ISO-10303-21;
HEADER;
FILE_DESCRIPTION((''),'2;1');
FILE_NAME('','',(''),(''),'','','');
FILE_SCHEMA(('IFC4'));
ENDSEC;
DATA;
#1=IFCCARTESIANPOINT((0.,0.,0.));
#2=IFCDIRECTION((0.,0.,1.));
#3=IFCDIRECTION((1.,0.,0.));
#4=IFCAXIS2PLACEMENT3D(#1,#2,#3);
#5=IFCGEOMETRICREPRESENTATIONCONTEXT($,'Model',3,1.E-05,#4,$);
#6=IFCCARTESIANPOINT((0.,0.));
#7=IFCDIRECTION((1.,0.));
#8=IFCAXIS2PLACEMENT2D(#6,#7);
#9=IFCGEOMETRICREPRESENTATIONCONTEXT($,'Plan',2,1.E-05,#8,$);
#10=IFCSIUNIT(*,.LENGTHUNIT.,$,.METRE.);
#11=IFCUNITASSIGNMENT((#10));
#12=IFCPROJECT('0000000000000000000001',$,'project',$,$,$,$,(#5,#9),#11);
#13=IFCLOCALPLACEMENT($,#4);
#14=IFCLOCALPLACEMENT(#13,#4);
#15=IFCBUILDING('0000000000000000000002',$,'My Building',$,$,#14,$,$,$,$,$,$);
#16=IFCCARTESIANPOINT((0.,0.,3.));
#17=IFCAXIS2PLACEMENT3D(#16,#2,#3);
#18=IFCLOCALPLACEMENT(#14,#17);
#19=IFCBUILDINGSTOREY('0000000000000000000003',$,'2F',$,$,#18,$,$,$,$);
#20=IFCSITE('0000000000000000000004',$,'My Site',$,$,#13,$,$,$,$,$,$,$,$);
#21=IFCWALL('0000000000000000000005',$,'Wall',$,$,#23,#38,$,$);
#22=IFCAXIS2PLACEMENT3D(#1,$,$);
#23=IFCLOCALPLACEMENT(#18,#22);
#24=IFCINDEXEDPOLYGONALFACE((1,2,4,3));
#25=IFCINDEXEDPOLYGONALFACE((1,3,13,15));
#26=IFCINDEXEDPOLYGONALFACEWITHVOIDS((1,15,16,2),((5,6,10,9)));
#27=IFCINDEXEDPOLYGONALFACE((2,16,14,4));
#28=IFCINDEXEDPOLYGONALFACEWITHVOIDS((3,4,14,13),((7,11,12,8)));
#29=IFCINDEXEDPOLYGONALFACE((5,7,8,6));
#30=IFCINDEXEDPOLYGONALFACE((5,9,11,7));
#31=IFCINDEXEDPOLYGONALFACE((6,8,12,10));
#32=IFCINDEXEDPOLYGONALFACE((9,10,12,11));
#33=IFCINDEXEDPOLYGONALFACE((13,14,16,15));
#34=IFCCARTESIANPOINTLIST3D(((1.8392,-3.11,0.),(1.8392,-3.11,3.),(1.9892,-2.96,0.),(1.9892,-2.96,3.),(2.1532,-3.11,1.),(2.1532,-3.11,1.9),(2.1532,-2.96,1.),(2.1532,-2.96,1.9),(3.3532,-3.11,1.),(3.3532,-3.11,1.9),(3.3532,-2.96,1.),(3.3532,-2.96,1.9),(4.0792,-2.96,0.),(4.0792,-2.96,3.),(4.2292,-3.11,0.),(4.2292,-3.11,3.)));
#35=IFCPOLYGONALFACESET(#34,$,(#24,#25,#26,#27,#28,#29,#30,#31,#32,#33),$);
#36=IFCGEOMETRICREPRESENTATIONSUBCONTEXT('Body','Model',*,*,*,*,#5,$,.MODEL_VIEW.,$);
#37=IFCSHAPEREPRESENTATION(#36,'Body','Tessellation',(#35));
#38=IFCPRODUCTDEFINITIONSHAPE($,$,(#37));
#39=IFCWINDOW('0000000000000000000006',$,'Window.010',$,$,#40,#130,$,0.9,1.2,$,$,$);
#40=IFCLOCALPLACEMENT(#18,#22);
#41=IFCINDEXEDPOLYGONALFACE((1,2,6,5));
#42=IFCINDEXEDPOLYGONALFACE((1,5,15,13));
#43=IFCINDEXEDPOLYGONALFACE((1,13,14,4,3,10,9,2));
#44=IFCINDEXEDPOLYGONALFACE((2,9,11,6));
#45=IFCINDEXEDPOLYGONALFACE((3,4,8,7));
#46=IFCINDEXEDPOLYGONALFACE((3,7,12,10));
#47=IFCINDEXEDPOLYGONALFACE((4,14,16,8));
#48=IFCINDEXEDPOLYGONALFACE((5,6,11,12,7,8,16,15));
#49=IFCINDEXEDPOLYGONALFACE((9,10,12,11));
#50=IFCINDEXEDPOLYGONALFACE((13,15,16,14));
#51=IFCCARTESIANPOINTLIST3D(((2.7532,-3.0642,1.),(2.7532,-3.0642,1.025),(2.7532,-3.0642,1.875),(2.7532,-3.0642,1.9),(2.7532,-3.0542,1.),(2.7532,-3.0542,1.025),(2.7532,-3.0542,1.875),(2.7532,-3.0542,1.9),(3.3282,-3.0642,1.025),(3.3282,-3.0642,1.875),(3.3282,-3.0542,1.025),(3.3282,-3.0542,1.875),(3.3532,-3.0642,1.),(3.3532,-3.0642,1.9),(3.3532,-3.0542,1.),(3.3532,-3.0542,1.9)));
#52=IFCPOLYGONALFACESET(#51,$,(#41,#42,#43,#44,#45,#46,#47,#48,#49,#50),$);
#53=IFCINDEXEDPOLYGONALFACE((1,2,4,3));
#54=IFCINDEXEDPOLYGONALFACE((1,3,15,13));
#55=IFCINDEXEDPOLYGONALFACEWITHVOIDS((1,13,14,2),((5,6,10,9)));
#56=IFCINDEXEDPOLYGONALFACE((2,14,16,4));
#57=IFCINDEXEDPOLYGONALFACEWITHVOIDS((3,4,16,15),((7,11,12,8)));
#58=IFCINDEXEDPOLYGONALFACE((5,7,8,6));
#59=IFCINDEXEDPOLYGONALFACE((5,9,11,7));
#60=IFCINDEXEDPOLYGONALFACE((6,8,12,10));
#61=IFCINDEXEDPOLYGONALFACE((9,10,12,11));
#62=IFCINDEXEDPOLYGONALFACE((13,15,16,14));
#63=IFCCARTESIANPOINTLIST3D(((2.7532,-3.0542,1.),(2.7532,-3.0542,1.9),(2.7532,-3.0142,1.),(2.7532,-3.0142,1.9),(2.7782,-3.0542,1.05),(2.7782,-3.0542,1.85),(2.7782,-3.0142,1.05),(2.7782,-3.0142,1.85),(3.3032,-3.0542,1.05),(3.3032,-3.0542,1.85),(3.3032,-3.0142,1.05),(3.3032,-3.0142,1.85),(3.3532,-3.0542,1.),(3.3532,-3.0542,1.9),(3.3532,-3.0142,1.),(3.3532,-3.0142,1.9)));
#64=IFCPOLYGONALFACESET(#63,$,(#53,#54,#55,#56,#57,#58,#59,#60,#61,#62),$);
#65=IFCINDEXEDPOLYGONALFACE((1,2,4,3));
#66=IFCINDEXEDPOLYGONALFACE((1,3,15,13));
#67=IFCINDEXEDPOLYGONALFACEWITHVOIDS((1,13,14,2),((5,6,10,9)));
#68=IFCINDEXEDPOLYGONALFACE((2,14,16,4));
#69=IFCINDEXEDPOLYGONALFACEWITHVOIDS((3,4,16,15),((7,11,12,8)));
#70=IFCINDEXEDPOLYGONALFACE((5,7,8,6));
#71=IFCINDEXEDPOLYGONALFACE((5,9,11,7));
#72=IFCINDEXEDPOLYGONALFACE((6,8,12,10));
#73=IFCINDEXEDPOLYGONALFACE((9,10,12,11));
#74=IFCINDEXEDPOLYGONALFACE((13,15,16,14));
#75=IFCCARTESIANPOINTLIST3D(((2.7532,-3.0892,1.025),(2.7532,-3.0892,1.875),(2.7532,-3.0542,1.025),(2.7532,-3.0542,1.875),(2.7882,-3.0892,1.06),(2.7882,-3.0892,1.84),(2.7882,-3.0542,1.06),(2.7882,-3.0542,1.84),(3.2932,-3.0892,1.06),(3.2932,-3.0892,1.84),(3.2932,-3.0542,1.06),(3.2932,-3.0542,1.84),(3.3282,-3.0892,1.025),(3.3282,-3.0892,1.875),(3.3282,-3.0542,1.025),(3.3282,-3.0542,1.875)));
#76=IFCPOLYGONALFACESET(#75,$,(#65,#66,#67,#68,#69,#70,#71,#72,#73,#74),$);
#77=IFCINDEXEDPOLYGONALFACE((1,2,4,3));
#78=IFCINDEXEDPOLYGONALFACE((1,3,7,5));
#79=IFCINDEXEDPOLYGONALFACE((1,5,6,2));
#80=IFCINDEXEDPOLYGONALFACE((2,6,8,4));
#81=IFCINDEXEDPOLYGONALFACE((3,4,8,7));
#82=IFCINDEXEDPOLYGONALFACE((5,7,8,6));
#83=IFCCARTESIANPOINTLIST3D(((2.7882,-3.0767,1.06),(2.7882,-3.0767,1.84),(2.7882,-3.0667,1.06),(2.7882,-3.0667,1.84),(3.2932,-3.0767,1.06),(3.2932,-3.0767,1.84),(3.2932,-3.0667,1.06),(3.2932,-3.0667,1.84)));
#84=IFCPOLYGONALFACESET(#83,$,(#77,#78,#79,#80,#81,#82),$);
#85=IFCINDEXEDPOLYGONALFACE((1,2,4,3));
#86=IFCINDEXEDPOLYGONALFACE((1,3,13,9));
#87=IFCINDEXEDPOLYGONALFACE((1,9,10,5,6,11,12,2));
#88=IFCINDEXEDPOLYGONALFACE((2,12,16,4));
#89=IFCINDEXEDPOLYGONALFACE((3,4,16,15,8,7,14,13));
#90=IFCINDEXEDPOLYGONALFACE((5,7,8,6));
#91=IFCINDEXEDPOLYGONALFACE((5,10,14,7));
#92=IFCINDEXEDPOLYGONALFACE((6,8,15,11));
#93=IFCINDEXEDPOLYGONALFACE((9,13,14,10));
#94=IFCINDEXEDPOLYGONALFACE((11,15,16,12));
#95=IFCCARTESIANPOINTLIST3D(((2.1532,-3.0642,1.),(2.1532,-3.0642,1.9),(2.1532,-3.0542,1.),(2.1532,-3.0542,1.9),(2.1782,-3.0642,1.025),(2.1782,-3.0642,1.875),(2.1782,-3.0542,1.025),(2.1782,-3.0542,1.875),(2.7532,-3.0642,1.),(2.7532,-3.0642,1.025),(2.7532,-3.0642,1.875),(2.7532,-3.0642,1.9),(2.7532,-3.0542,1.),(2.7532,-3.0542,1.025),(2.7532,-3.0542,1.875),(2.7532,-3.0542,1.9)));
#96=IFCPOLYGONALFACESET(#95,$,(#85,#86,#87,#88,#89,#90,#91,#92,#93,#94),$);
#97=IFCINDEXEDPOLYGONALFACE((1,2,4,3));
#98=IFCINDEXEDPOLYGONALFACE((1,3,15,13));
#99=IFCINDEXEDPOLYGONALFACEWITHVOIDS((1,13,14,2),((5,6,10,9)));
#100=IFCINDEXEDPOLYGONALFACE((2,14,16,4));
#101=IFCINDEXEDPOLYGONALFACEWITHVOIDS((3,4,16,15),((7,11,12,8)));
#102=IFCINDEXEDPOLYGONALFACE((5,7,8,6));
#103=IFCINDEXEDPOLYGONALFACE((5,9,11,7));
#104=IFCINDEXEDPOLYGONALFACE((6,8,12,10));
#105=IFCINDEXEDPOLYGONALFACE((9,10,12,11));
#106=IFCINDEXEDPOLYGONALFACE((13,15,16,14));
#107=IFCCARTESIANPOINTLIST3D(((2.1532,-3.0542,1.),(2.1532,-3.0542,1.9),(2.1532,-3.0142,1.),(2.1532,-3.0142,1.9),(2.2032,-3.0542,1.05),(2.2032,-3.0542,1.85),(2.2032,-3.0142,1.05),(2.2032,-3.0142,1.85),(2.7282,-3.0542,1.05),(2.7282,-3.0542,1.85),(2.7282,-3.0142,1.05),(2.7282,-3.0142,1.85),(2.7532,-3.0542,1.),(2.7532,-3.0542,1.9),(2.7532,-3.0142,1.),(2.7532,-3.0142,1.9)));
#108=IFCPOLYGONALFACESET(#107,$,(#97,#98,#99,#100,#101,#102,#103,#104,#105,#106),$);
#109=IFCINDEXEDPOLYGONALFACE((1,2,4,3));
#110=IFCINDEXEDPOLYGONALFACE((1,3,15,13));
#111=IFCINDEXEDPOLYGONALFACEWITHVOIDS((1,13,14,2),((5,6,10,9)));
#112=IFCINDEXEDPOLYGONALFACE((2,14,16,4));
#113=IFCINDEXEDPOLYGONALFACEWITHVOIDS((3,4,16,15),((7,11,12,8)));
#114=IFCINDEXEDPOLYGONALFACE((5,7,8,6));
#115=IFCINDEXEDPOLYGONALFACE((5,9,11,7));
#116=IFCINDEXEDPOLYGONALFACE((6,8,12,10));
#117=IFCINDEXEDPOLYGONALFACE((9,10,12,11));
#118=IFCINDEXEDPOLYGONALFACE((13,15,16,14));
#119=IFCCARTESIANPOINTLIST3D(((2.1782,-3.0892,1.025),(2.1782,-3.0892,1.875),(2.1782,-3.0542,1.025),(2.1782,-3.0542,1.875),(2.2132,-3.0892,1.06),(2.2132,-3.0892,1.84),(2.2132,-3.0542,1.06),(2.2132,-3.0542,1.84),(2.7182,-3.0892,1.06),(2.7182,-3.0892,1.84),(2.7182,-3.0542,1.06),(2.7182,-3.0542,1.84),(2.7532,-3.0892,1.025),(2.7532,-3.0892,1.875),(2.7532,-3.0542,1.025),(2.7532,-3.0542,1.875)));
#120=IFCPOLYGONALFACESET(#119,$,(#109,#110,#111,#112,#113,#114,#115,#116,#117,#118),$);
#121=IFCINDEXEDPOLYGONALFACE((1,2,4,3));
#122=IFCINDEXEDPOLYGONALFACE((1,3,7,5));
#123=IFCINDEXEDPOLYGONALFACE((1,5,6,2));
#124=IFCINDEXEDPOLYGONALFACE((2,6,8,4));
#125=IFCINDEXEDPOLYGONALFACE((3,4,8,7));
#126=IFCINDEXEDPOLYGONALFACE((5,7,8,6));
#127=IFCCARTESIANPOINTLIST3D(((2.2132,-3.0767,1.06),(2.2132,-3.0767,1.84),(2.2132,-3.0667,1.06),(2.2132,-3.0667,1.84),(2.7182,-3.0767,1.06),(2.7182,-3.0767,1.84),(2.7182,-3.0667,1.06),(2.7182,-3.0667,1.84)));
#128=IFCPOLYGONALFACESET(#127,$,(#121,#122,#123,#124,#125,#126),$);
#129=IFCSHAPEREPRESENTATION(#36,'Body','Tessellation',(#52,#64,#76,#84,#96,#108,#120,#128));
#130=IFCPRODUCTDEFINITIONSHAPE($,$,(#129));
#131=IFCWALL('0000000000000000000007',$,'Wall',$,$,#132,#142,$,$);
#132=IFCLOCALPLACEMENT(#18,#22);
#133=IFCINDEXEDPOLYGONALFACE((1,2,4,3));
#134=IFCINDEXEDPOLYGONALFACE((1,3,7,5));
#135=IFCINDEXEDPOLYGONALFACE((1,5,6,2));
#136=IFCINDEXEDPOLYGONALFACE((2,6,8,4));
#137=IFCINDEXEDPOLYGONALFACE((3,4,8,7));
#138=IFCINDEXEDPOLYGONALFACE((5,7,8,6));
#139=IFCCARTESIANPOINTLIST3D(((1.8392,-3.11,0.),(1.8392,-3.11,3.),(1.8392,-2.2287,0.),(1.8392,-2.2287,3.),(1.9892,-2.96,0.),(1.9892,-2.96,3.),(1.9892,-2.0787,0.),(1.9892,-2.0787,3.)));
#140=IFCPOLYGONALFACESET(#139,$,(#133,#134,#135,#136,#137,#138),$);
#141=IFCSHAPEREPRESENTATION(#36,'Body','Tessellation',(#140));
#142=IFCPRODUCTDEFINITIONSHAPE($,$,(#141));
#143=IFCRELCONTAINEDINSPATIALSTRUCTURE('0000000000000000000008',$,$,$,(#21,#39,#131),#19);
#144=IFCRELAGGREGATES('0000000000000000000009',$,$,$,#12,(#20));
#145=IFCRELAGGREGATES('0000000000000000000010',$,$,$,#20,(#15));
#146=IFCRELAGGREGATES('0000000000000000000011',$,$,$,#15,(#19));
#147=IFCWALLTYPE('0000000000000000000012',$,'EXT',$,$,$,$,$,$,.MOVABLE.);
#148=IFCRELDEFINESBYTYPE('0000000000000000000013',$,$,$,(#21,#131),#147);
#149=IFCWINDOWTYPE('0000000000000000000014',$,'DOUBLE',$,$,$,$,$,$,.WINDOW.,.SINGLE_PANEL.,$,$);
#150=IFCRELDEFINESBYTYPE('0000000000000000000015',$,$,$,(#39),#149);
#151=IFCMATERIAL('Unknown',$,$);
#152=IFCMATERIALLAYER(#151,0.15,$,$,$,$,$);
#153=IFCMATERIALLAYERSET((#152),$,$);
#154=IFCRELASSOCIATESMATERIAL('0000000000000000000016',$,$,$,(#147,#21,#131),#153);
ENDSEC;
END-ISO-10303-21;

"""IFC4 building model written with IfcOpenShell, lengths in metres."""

from ifc_helpers import new_model, entity, si_unit, frame, origin_with_axes, origin_2d_with_axis, place, context, subcontext, project, spatial, line, indexed_curve, outline, extrude, shape, source, transform, mapped, material, layer, layer_set, layer_usage, type_object, type_shapes, element, fill, save


model = new_model("IFC4")

# Units and contexts
model_context = context("Model", 3, precision=1e-05, world=origin_with_axes())
plan_context = context("Plan", 2, precision=1e-05, world=origin_2d_with_axis())
body_context_1 = subcontext(model_context, "Body", "Model", "MODEL_VIEW")
body_context_2 = subcontext(plan_context, "Body", "Plan", "PLAN_VIEW")
ifc_project = project(units=[si_unit("LENGTHUNIT", "METRE")], contexts=[model_context, plan_context])

# Site, building, storey
site_placement = place(None, origin_with_axes())
site = spatial("IfcSite", under=ifc_project, at=site_placement, Name="My Site")
building_placement = place(site_placement, origin_with_axes())
building = spatial("IfcBuilding", under=site, at=building_placement, Name="My Building")
storey_placement = place(building_placement, frame((0.0, 0.0, 3.0), z_axis=(0.0, 0.0, 1.0), x_axis=(1.0, 0.0, 0.0)))
storey = spatial("IfcBuildingStorey", under=building, at=storey_placement, Name="2F")

# Shared definitions
ifc_material = material(Name="Unknown")

# Wall, opening, window
ifc_layer_1 = layer(ifc_material, 0.15)
ifc_layer_set_1 = layer_set([ifc_layer_1])
ifc_layer_usage_1 = layer_usage(ifc_layer_set_1, "AXIS2", "POSITIVE", -0.15)
wall_type_1 = type_object("IfcWallType", Name="EXT", PredefinedType="MOVABLE", material=ifc_layer_set_1)
wall_1_placement = place(storey_placement, frame((4.2292, -3.11, 0.0), z_axis=(0.0, 0.0, 1.0), x_axis=(-1.0, 0.0, 0.0)))
wall_1 = element("IfcWall", 1, at=wall_1_placement, inside=storey, type_object=wall_type_1, material=ifc_layer_usage_1, Name="Wall", context=body_context_1, shape_type="SweptSolid", body=[
    extrude(outline(indexed_curve([(0.15, -0.15), (0.0, 0.0), (2.39, 0.0), (2.24, -0.15)], segments=[line(1, 2, 3, 4, 1)])), origin_with_axes(), (0.0, 0.0, 1.0), 3.0),
])
placement_1 = place(storey_placement, frame((3.3532, -2.9642, 1.0), z_axis=(0.0, 0.0, 1.0), x_axis=(-1.0, 0.000001, 0.0)))
opening_1 = element("IfcOpeningElement", 2, at=placement_1, cuts=wall_1, PredefinedType="OPENING", context=body_context_1, shape_type="SweptSolid", body=[
    extrude(outline(indexed_curve([(0.0, 0.0), (1.2, 0.0), (1.2, 0.9), (0.0, 0.9)], segments=[line(1, 2, 3, 4, 1)])), frame((0.0, -0.6, 0.0), z_axis=(0.0, -1.0, 0.0), x_axis=(1.0, 0.0, 0.0)), (0.0, 0.0, -1.0), 1.2),
])
window_type_1 = type_object("IfcWindowType", Name="DOUBLE", PartitioningType="SINGLE_PANEL", PredefinedType="WINDOW")
shared_shape_1 = source(origin_with_axes(), body_context_1, "Body", "SweptSolid", [
    extrude(outline(indexed_curve([(0.6, 0.0), (0.0, 0.0), (0.0, 0.9), (0.6, 0.9), (0.6, 0.875), (0.025, 0.875), (0.025, 0.025), (0.6, 0.025)], segments=[line(1, 2, 3, 4, 5, 6, 7, 8, 1)])), frame((0.0, 0.09, 0.0), z_axis=(0.0, -1.0, 0.0), x_axis=(1.0, 0.0, 0.0)), (0.0, 0.0, -1.0), 0.01),
    extrude(outline(indexed_curve([(0.0, 0.0), (0.6, 0.0), (0.6, 0.9), (0.0, 0.9)], segments=[line(1, 2, 3, 4, 1)]), holes=[indexed_curve([(0.05, 0.05), (0.575, 0.05), (0.575, 0.85), (0.05, 0.85)], segments=[line(1, 2, 3, 4, 1)])]), frame((0.0, 0.05, 0.0), z_axis=(0.0, -1.0, 0.0), x_axis=(1.0, 0.0, 0.0)), (0.0, 0.0, -1.0), 0.04),
    extrude(outline(indexed_curve([(0.0, 0.0), (0.575, 0.0), (0.575, 0.85), (0.0, 0.85)], segments=[line(1, 2, 3, 4, 1)]), holes=[indexed_curve([(0.035, 0.035), (0.54, 0.035), (0.54, 0.815), (0.035, 0.815)], segments=[line(1, 2, 3, 4, 1)])]), frame((0.025, 0.09, 0.025), z_axis=(0.0, -1.0, 0.0), x_axis=(1.0, 0.0, 0.0)), (0.0, 0.0, -1.0), 0.035),
    extrude(outline(indexed_curve([(0.035, 0.035), (0.54, 0.035), (0.54, 0.815), (0.035, 0.815)], segments=[line(1, 2, 3, 4, 1)])), frame((0.025, 0.1025, 0.025), z_axis=(0.0, -1.0, 0.0), x_axis=(1.0, 0.0, 0.0)), (0.0, 0.0, -1.0), 0.01),
    extrude(outline(indexed_curve([(0.0, 0.9), (0.6, 0.9), (0.6, 0.0), (0.0, 0.0), (0.0, 0.025), (0.575, 0.025), (0.575, 0.875), (0.0, 0.875)], segments=[line(1, 2, 3, 4, 5, 6, 7, 8, 1)])), frame((0.6, 0.09, 0.0), z_axis=(0.0, -1.0, 0.0), x_axis=(1.0, 0.0, 0.0)), (0.0, 0.0, -1.0), 0.01),
    extrude(outline(indexed_curve([(0.0, 0.0), (0.6, 0.0), (0.6, 0.9), (0.0, 0.9)], segments=[line(1, 2, 3, 4, 1)]), holes=[indexed_curve([(0.025, 0.05), (0.55, 0.05), (0.55, 0.85), (0.025, 0.85)], segments=[line(1, 2, 3, 4, 1)])]), frame((0.6, 0.05, 0.0), z_axis=(0.0, -1.0, 0.0), x_axis=(1.0, 0.0, 0.0)), (0.0, 0.0, -1.0), 0.04),
    extrude(outline(indexed_curve([(0.0, 0.0), (0.575, 0.0), (0.575, 0.85), (0.0, 0.85)], segments=[line(1, 2, 3, 4, 1)]), holes=[indexed_curve([(0.035, 0.035), (0.54, 0.035), (0.54, 0.815), (0.035, 0.815)], segments=[line(1, 2, 3, 4, 1)])]), frame((0.6, 0.09, 0.025), z_axis=(0.0, -1.0, 0.0), x_axis=(1.0, 0.0, 0.0)), (0.0, 0.0, -1.0), 0.035),
    extrude(outline(indexed_curve([(0.035, 0.815), (0.54, 0.815), (0.54, 0.035), (0.035, 0.035), (0.035, 0.815)])), frame((0.6, 0.1025, 0.025), z_axis=(0.0, -1.0, 0.0), x_axis=(1.0, 0.0, 0.0)), (0.0, 0.0, -1.0), 0.01),
])
shared_shape_2 = source(origin_with_axes(), body_context_2, "Body", "Curve2D", [
    entity("IfcIndexedPolyCurve", entity("IfcCartesianPointList2D", [[0.05, 0.05], [0.575, 0.05]])),
    entity("IfcIndexedPolyCurve", entity("IfcCartesianPointList2D", [[0.0, 0.1], [0.025, 0.1], [0.025, 0.09], [0.05, 0.09], [0.05, 0.05], [0.0, 0.05]]), [entity("IfcLineIndex", [1, 2, 3, 4, 5, 6, 1])]),
    entity("IfcIndexedPolyCurve", entity("IfcCartesianPointList2D", [[0.6, 0.1], [0.6, 0.1], [0.6, 0.09], [0.575, 0.09], [0.575, 0.05], [0.6, 0.05]])),
    entity("IfcIndexedPolyCurve", entity("IfcCartesianPointList2D", [[0.025, 0.09], [0.06, 0.09], [0.06, 0.125], [0.025, 0.125]]), [entity("IfcLineIndex", [1, 2, 3, 4, 1])]),
    entity("IfcIndexedPolyCurve", entity("IfcCartesianPointList2D", [[0.6, 0.09], [0.565, 0.09], [0.565, 0.125], [0.6, 0.125]]), [entity("IfcLineIndex", [1, 2, 3, 4, 1])]),
    entity("IfcIndexedPolyCurve", entity("IfcCartesianPointList2D", [[0.06, 0.09], [0.565, 0.09]])),
    entity("IfcIndexedPolyCurve", entity("IfcCartesianPointList2D", [[0.06, 0.125], [0.565, 0.125]])),
    entity("IfcIndexedPolyCurve", entity("IfcCartesianPointList2D", [[0.06, 0.1075], [0.565, 0.1075]])),
    entity("IfcIndexedPolyCurve", entity("IfcCartesianPointList2D", [[0.625, 0.05], [1.15, 0.05]])),
    entity("IfcIndexedPolyCurve", entity("IfcCartesianPointList2D", [[0.6, 0.1], [0.6, 0.1], [0.6, 0.09], [0.625, 0.09], [0.625, 0.05], [0.6, 0.05]])),
    entity("IfcIndexedPolyCurve", entity("IfcCartesianPointList2D", [[1.2, 0.1], [1.175, 0.1], [1.175, 0.09], [1.15, 0.09], [1.15, 0.05], [1.2, 0.05]]), [entity("IfcLineIndex", [1, 2, 3, 4, 5, 6, 1])]),
    entity("IfcIndexedPolyCurve", entity("IfcCartesianPointList2D", [[0.6, 0.09], [0.635, 0.09], [0.635, 0.125], [0.6, 0.125]]), [entity("IfcLineIndex", [1, 2, 3, 4, 1])]),
    entity("IfcIndexedPolyCurve", entity("IfcCartesianPointList2D", [[1.175, 0.09], [1.14, 0.09], [1.14, 0.125], [1.175, 0.125]]), [entity("IfcLineIndex", [1, 2, 3, 4, 1])]),
    entity("IfcIndexedPolyCurve", entity("IfcCartesianPointList2D", [[0.635, 0.09], [1.14, 0.09]])),
    entity("IfcIndexedPolyCurve", entity("IfcCartesianPointList2D", [[0.635, 0.125], [1.14, 0.125]])),
    entity("IfcIndexedPolyCurve", entity("IfcCartesianPointList2D", [[0.635, 0.1075], [1.14, 0.1075]])),
])
type_shapes(window_type_1, [shared_shape_1, shared_shape_2])
window_1 = element("IfcWindow", 3, at=placement_1, inside=storey, type_object=window_type_1, Name="Window.010", OverallHeight=0.9, OverallWidth=1.2, shapes=[
    shape(body_context_1, "Body", "MappedRepresentation", [mapped(shared_shape_1, transform((0.0, 0.0, 0.0), x_axis=(1.0, 0.0, 0.0), y_axis=(0.0, 1.0, 0.0), z_axis=(0.0, 0.0, 1.0), scale=1.0))]),
    shape(body_context_2, "Body", "MappedRepresentation", [mapped(shared_shape_2, transform((0.0, 0.0, 0.0), x_axis=(1.0, 0.0, 0.0), y_axis=(0.0, 1.0, 0.0), z_axis=(0.0, 0.0, 1.0), scale=1.0))]),
])
fill(opening_1, window_1)

# Wall
ifc_layer_usage_2 = layer_usage(ifc_layer_set_1, "AXIS2", "POSITIVE", -0.15)
wall_2_placement = place(storey_placement, frame((1.8392, -3.11, 0.0), z_axis=(0.0, 0.0, 1.0), x_axis=(0.0, 1.0, 0.0)))
element("IfcWall", 4, at=wall_2_placement, inside=storey, type_object=wall_type_1, material=ifc_layer_usage_2, Name="Wall", context=body_context_1, shape_type="SweptSolid", body=[
    extrude(outline(indexed_curve([(0.15, -0.15), (0.0, 0.0), (0.8813, 0.0), (1.0313, -0.15)], segments=[line(1, 2, 3, 4, 1)])), origin_with_axes(), (0.0, 0.0, 1.0), 3.0),
])

save(model, "model.ifc")
